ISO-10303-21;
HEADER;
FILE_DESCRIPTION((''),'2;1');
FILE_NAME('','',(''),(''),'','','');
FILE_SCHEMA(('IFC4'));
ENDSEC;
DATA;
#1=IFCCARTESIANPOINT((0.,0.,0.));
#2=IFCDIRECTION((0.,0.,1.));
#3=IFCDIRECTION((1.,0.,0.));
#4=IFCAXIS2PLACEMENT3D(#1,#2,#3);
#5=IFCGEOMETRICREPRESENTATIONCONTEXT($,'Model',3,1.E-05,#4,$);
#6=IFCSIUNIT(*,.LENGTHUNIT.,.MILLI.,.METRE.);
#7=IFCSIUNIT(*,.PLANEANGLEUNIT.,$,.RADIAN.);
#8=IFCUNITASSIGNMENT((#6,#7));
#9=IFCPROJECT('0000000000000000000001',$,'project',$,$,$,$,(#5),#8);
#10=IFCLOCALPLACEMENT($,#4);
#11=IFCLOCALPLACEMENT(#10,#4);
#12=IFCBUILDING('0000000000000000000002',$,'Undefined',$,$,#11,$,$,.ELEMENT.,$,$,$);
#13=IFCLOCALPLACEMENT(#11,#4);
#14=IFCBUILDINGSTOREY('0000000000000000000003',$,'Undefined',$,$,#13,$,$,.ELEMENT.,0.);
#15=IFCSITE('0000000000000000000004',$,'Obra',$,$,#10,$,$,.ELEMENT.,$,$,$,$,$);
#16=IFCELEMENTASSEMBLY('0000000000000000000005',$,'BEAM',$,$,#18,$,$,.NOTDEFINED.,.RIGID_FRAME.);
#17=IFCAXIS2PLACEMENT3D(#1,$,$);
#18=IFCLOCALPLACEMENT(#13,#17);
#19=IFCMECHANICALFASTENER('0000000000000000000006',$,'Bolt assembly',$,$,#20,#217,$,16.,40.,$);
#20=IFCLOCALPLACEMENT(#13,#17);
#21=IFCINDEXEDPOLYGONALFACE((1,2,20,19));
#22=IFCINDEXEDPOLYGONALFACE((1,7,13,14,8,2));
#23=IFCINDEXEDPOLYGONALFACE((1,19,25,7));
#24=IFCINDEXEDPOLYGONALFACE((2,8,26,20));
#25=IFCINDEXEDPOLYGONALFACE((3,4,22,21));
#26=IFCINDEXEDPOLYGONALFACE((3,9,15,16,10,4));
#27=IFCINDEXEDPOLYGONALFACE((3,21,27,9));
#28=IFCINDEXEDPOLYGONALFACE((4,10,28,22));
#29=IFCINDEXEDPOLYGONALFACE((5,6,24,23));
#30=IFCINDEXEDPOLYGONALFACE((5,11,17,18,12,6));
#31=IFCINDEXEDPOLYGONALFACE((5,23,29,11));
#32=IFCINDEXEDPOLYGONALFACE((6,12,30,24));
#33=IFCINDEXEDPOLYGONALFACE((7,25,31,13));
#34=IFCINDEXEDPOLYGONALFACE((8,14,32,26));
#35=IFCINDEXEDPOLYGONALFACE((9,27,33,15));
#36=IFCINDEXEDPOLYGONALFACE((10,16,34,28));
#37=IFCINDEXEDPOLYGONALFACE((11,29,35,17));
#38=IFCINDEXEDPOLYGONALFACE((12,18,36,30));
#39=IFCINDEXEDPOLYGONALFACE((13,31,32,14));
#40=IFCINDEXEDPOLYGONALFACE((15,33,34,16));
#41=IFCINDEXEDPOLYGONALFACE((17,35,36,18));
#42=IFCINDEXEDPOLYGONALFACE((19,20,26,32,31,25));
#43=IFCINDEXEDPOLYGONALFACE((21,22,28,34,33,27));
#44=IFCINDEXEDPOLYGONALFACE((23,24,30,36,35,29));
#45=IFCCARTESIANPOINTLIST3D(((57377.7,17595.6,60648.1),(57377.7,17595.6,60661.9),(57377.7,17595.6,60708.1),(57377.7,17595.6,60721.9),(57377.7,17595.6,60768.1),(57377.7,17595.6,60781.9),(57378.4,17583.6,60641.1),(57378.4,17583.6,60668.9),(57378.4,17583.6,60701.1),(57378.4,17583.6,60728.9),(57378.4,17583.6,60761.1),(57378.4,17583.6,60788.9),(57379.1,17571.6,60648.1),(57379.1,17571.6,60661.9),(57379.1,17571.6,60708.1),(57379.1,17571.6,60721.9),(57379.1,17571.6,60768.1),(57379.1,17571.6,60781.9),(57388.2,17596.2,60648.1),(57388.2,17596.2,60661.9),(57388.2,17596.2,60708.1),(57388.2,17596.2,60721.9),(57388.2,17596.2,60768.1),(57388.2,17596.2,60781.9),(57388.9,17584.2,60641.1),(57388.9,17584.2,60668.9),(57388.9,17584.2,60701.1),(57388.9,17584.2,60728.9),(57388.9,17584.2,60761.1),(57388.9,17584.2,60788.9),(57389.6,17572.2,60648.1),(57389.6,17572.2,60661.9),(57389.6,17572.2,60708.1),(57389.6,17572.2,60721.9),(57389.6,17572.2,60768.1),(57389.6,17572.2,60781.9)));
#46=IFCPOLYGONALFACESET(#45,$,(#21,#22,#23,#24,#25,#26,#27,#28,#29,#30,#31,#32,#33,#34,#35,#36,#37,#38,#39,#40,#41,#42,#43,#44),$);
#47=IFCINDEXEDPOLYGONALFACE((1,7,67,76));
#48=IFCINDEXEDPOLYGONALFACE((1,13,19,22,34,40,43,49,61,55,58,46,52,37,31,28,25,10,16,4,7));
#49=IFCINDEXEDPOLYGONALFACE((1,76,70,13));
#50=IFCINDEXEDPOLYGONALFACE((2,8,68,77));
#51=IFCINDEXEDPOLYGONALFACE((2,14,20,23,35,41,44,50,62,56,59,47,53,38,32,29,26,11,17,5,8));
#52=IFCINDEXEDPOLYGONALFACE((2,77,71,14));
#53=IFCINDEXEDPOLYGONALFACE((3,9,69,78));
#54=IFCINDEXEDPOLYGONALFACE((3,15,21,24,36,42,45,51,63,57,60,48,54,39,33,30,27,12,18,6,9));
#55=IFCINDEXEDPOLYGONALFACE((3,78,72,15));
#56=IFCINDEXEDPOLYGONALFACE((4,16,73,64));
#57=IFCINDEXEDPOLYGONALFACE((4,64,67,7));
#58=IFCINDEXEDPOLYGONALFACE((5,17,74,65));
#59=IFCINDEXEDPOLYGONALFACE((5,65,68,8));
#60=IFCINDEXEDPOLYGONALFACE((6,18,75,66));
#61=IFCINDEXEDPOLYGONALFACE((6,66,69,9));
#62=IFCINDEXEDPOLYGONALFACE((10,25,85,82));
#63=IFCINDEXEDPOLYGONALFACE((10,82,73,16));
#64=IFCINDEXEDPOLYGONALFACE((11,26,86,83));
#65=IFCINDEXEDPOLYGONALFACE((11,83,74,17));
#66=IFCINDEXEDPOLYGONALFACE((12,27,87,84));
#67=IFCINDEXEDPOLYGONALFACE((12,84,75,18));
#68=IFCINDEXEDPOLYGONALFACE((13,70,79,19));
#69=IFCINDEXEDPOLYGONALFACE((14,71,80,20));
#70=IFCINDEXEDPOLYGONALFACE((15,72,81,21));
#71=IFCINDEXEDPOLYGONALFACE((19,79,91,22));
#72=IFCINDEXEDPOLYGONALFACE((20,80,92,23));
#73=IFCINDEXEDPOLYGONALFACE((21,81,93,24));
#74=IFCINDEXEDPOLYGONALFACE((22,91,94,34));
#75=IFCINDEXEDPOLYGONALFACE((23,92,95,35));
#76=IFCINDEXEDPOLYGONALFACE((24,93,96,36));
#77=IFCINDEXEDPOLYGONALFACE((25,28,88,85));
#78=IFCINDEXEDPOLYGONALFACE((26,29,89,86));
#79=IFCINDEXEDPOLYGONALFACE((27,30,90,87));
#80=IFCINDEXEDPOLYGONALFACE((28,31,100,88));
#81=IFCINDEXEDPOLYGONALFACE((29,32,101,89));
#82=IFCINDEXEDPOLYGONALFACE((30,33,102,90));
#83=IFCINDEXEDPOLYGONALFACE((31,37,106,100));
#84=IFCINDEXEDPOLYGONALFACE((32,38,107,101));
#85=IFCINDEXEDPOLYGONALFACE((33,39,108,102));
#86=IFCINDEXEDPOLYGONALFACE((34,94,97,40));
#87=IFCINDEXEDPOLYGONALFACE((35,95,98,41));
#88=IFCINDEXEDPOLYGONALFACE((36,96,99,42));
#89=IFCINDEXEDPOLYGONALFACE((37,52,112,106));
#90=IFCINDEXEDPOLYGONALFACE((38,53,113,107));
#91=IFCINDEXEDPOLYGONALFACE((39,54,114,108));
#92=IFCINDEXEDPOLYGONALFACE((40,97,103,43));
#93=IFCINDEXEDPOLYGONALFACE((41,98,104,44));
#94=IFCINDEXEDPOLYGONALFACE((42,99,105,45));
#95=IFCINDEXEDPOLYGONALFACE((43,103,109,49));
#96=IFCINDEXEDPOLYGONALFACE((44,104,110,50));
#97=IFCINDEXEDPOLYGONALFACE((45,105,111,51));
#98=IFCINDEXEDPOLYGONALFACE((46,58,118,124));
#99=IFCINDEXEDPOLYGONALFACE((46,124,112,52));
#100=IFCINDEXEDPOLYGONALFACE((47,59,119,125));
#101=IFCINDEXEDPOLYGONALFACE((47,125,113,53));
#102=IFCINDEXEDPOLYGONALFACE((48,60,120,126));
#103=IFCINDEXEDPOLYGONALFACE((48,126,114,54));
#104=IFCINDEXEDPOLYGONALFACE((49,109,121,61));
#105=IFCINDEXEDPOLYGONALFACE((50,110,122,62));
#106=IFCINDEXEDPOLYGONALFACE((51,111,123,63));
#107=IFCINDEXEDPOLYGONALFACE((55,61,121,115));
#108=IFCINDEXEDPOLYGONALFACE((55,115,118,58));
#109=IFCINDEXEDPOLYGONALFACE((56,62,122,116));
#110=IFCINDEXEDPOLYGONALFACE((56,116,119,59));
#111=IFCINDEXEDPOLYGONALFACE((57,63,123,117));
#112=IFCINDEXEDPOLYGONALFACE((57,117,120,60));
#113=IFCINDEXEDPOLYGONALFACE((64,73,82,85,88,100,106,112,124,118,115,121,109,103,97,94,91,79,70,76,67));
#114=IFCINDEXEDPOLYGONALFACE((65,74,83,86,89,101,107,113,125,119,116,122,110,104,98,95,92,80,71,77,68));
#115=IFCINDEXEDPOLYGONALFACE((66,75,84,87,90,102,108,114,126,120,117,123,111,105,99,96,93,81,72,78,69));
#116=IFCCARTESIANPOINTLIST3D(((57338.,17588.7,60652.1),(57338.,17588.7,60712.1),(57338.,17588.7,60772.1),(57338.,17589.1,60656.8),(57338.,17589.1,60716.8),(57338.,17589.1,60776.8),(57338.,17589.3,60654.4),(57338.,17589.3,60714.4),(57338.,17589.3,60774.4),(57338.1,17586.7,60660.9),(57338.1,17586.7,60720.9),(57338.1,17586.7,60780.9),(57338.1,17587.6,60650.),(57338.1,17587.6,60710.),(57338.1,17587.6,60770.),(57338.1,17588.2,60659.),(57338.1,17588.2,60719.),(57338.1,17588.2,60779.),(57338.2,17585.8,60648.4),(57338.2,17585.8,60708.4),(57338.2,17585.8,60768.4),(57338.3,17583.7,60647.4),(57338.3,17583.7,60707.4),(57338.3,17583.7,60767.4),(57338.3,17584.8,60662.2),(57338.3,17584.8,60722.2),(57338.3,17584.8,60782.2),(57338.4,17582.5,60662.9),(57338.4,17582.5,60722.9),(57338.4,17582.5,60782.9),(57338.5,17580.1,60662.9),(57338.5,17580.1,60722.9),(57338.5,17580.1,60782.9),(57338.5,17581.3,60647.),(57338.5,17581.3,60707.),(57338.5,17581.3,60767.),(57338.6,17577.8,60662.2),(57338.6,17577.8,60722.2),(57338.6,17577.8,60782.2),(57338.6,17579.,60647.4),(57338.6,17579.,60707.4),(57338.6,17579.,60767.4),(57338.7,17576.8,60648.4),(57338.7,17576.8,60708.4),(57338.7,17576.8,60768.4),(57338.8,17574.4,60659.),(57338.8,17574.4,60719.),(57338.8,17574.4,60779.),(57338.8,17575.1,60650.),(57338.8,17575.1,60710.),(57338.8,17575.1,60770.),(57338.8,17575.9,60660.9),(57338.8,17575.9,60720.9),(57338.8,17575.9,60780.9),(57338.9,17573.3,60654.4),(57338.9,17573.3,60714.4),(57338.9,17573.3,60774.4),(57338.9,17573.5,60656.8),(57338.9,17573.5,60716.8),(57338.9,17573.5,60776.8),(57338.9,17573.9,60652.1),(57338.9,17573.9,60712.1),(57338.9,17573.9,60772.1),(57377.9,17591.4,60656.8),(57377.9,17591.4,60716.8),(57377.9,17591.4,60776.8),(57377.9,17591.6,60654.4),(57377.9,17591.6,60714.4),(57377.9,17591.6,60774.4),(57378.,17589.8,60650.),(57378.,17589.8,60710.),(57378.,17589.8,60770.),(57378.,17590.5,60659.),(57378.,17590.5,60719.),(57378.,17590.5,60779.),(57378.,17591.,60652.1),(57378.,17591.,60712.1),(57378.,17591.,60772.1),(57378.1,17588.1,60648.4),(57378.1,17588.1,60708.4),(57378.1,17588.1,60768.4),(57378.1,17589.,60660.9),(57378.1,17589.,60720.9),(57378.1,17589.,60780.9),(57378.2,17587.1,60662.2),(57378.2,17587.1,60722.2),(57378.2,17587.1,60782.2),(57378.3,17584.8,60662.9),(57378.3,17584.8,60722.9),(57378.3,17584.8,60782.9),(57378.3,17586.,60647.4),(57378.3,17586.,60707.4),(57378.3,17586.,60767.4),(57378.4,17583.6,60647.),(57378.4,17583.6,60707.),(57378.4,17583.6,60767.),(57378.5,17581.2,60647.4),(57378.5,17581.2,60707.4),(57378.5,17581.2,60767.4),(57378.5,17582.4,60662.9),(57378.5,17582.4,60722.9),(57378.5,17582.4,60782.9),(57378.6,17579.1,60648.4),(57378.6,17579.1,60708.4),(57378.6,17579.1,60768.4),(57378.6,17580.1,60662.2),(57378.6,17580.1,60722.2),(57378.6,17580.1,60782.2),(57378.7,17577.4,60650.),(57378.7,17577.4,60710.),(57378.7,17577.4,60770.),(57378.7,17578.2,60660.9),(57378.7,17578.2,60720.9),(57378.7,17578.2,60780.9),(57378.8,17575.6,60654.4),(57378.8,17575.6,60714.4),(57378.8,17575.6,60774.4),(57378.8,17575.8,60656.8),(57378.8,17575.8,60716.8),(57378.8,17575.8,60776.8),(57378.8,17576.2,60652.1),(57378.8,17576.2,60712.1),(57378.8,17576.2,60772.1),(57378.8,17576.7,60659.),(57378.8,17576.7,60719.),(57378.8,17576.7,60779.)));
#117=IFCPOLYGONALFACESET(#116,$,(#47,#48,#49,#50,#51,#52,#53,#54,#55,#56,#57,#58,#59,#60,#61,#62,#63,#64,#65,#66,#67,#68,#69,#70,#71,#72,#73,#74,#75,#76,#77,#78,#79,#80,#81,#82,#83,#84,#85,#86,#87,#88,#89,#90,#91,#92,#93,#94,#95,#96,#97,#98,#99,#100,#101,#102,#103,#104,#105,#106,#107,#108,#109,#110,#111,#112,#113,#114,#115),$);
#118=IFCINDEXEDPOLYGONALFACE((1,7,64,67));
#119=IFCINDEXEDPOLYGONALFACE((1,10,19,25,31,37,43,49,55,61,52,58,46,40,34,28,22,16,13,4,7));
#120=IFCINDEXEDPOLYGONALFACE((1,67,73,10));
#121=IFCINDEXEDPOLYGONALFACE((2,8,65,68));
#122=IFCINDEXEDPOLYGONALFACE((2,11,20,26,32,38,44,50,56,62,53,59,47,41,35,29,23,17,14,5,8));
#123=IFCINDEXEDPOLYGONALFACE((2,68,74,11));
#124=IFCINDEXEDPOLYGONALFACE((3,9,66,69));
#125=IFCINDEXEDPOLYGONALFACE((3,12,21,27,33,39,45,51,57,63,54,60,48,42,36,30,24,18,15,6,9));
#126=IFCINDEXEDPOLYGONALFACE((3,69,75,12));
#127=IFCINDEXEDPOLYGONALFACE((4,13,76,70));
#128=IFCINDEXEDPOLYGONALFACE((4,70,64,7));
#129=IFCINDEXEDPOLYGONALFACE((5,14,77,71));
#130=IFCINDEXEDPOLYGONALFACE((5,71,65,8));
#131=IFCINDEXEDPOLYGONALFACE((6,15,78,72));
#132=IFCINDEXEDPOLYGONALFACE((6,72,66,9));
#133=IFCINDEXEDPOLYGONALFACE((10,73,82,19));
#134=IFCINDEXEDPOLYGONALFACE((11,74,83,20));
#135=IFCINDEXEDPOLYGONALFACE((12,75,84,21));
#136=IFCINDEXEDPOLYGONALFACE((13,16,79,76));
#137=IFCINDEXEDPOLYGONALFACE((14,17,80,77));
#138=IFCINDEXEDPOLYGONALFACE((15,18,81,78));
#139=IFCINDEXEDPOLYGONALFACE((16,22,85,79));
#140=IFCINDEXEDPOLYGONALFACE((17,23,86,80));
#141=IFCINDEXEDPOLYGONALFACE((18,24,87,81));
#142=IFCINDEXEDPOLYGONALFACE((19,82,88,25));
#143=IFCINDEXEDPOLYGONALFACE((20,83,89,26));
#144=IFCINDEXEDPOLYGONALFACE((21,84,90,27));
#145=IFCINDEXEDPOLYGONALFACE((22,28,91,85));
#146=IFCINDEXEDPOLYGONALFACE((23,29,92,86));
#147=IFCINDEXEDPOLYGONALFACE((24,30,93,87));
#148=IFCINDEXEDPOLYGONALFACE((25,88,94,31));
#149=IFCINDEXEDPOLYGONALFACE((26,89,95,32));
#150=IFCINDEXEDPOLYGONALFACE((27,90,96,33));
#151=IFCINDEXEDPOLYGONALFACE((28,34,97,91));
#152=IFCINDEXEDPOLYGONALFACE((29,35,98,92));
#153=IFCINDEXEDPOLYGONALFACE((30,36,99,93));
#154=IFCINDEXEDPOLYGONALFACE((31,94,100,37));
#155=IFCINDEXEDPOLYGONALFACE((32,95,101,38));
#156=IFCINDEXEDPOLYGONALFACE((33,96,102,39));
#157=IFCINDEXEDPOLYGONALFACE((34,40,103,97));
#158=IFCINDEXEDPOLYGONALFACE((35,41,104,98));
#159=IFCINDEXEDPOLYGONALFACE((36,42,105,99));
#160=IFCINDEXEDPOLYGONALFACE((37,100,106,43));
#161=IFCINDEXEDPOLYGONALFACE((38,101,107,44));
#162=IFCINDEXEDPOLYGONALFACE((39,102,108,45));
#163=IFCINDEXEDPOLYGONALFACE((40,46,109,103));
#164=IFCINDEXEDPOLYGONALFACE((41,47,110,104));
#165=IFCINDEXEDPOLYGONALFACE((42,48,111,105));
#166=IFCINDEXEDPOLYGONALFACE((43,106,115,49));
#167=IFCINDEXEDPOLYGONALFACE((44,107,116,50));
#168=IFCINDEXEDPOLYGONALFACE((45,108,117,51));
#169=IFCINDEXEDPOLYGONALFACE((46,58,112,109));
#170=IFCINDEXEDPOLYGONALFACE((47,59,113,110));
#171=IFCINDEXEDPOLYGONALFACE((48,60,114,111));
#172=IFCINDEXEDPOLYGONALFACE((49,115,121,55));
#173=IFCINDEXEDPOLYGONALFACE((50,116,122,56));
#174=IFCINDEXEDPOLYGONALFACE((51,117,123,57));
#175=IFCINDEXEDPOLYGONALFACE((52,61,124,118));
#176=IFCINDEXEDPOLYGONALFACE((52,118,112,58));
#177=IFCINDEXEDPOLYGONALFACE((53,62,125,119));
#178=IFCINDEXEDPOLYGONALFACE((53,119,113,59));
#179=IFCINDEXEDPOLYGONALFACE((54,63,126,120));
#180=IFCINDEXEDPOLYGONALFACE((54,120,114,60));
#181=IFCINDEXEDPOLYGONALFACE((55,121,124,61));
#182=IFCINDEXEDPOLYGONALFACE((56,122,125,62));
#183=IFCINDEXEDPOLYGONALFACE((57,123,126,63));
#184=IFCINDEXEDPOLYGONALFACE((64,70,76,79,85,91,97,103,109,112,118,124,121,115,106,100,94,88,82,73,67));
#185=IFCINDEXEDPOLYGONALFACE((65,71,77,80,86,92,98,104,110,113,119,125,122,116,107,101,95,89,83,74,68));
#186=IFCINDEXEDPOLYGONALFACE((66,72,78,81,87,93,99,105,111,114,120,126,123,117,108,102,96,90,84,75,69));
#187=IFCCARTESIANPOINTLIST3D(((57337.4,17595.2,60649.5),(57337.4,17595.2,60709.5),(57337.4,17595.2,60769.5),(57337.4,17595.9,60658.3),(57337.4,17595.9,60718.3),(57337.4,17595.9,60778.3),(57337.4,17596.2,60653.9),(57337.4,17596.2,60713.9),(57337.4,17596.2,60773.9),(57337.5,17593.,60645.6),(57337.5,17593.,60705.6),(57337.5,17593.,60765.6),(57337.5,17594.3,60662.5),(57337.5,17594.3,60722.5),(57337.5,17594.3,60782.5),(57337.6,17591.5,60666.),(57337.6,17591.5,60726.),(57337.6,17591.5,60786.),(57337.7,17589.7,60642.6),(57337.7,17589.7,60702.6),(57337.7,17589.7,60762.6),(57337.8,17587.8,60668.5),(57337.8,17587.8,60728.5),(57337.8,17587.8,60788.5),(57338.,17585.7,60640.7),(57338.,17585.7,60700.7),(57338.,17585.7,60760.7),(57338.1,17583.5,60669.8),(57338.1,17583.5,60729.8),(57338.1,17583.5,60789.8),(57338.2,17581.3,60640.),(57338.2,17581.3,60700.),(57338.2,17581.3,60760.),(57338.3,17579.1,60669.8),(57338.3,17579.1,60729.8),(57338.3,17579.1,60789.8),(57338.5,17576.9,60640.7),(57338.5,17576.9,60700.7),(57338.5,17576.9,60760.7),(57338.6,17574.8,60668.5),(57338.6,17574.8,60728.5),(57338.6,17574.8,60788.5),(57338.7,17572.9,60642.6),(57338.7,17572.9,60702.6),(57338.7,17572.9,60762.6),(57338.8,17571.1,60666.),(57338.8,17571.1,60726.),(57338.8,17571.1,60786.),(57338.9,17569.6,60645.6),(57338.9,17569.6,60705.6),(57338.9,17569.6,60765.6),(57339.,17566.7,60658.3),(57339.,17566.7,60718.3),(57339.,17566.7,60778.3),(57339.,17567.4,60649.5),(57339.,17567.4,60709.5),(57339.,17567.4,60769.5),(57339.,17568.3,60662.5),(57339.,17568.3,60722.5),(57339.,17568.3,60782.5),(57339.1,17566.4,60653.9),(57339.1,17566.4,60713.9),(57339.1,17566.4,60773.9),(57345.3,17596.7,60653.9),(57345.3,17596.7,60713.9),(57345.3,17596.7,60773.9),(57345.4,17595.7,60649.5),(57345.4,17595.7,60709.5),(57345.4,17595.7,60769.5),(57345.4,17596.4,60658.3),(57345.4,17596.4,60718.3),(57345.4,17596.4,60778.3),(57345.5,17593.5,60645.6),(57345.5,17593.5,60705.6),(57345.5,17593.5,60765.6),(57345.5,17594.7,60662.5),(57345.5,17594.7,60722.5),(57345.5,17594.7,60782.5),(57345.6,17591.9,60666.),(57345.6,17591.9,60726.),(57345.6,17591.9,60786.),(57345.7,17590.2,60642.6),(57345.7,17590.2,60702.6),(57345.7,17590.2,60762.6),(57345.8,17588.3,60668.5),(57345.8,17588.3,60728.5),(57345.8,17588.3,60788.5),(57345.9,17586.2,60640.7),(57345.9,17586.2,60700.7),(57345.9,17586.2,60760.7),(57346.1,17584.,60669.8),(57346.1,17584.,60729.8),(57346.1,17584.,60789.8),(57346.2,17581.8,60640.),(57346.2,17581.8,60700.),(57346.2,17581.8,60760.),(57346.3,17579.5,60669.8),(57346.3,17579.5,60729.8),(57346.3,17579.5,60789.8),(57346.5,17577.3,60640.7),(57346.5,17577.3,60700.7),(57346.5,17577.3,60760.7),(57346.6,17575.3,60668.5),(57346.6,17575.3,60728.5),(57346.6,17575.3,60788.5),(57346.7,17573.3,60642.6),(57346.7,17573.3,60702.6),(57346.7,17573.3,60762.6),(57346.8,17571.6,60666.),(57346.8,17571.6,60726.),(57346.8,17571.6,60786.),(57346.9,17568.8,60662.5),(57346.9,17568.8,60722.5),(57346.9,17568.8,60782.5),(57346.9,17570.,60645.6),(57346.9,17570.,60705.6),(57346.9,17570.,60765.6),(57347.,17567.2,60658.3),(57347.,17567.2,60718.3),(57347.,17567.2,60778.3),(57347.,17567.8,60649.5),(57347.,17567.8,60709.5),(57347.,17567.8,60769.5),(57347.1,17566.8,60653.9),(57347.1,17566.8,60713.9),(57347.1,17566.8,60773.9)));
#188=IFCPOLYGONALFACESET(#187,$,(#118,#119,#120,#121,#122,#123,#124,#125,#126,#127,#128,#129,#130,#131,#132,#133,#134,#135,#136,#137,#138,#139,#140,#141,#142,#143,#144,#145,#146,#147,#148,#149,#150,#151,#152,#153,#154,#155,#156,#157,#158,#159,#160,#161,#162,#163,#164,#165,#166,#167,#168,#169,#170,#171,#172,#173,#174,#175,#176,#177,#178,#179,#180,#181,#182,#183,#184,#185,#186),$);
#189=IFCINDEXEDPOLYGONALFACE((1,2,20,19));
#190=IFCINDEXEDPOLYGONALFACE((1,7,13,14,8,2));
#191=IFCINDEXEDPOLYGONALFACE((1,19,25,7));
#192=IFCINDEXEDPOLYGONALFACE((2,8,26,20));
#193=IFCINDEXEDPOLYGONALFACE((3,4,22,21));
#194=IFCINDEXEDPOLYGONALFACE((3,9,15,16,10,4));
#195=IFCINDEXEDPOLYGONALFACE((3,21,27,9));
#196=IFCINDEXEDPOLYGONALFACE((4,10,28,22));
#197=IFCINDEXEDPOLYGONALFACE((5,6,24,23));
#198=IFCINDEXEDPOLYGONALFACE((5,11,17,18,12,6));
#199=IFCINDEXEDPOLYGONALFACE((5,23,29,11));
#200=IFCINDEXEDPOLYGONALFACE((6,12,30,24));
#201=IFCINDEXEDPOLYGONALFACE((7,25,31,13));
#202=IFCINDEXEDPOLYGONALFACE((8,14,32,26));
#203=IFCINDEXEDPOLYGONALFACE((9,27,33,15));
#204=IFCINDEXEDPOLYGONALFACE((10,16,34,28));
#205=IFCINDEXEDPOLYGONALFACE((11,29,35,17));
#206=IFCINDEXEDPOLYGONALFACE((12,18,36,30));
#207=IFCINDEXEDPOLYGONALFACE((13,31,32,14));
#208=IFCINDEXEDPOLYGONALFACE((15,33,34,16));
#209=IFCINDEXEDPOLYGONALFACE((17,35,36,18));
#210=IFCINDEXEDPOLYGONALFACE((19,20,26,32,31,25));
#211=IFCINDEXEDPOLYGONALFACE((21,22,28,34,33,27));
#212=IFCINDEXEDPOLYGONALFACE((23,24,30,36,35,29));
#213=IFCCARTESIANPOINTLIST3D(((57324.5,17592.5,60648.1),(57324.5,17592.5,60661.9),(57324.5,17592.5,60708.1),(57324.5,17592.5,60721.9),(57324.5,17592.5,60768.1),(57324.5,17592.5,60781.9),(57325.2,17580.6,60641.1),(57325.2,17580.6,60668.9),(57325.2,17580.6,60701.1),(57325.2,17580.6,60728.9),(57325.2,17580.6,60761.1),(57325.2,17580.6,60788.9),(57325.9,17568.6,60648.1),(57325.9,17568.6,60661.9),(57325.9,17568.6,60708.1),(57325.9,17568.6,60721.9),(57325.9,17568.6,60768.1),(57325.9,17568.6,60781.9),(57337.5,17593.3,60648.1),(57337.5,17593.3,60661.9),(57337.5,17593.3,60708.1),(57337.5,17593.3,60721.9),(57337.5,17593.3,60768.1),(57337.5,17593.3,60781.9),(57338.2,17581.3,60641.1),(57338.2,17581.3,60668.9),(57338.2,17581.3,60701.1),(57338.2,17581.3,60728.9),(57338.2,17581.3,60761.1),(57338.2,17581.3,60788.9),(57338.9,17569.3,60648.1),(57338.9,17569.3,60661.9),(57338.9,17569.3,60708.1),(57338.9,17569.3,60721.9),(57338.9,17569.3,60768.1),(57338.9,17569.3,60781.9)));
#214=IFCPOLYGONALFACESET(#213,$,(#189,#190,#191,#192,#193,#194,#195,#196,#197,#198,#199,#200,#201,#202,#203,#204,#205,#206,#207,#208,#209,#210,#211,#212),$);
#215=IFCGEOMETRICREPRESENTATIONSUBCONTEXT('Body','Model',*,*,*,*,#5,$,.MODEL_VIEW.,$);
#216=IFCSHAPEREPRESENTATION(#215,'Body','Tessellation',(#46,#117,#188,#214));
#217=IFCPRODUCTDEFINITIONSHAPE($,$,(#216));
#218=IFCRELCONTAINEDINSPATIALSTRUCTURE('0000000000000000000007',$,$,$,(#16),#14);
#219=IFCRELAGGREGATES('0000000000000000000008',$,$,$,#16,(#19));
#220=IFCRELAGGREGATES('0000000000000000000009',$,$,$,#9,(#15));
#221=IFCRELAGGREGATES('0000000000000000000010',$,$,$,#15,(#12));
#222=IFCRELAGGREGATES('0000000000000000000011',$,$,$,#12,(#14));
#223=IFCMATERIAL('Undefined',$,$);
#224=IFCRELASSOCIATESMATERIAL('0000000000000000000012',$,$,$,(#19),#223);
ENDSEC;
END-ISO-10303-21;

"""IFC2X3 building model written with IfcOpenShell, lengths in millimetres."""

from ifc_helpers import new_model, si_unit, frame, origin_with_axes, origin_2d_with_axis, place, context, subcontext, project, spatial, polyline, circle, outline, extrude, source, transform, mapped, material, element, aggregate, save


model = new_model("IFC2X3")

# Units and contexts
model_context = context("Model", 3, precision=1e-05, world=origin_with_axes())
body_context = subcontext(model_context, "Body", "Model", "MODEL_VIEW")
ifc_project = project(units=[si_unit("LENGTHUNIT", "METRE", prefix="MILLI"), si_unit("PLANEANGLEUNIT", "RADIAN")], contexts=[model_context])

# Site, building, storey
site_placement = place(None, origin_with_axes())
site = spatial("IfcSite", under=ifc_project, at=site_placement, Name="Obra", CompositionType="ELEMENT")
building_placement = place(site_placement, origin_with_axes())
building = spatial("IfcBuilding", under=site, at=building_placement, Name="Undefined", CompositionType="ELEMENT")
storey_placement = place(building_placement, origin_with_axes())
storey = spatial("IfcBuildingStorey", under=building, at=storey_placement, Name="Undefined", CompositionType="ELEMENT", Elevation=0.0)

# Element assembly, mechanical fastener
ifc_material_1 = material(Name="Undefined")
assembly_1_placement = place(storey_placement, origin_with_axes())
assembly_1 = element("IfcElementAssembly", 1, at=assembly_1_placement, inside=storey, Name="BEAM", AssemblyPlace="NOTDEFINED", PredefinedType="RIGID_FRAME")
shared_shape_1 = source(origin_with_axes(), body_context, "Body", "SweptSolid", [
    extrude(outline(polyline([(13.9, 0.0), (6.9, 12.0), (-6.9, 12.0), (-13.9, 0.0), (-6.9, -12.0), (6.9, -12.0), (13.9, 0.0)])), frame((0.0, -45.9, 0.0), z_axis=(0.0, 1.0, 0.0), x_axis=(1.0, 0.0, 0.0)), (0.0, 0.0, 1.0), 10.6),
    extrude(circle(Radius=8.0, at=origin_2d_with_axis()), frame((0.0, -35.3, 0.0), z_axis=(0.0, 1.0, 0.0), x_axis=(1.0, 0.0, 0.0)), (0.0, 0.0, 1.0), 40.0),
    extrude(circle(Radius=15.0, at=origin_2d_with_axis()), frame((0.0, -3.1, 0.0), z_axis=(0.0, 1.0, 0.0), x_axis=(1.0, 0.0, 0.0)), (0.0, 0.0, 1.0), 8.0),
    extrude(outline(polyline([(13.9, 0.0), (6.9, 12.0), (-6.9, 12.0), (-13.9, 0.0), (-6.9, -12.0), (6.9, -12.0), (13.9, 0.0)])), frame((0.0, 4.9, 0.0), z_axis=(0.0, 1.0, 0.0), x_axis=(1.0, 0.0, 0.0)), (0.0, 0.0, 1.0), 13.0),
])
mechanical_fastener_1_placement = place(assembly_1_placement, frame((57346.0, 17531.7, 60835.0), z_axis=(-0.057107, 0.998368, 0.0), x_axis=(0.0, 0.0, -1.0)))
mechanical_fastener_1 = element("IfcMechanicalFastener", 2, at=mechanical_fastener_1_placement, material=ifc_material_1, Name="Bolt assembly", NominalDiameter=16.0, NominalLength=40.0, context=body_context, shape_type="MappedRepresentation", body=[
    mapped(shared_shape_1, transform((60.0, 0.0, 50.0))),
    mapped(shared_shape_1, transform((120.0, 0.0, 50.0))),
    mapped(shared_shape_1, transform((180.0, 0.0, 50.0))),
])
aggregate(assembly_1, [mechanical_fastener_1])

save(model, "model.ifc")
